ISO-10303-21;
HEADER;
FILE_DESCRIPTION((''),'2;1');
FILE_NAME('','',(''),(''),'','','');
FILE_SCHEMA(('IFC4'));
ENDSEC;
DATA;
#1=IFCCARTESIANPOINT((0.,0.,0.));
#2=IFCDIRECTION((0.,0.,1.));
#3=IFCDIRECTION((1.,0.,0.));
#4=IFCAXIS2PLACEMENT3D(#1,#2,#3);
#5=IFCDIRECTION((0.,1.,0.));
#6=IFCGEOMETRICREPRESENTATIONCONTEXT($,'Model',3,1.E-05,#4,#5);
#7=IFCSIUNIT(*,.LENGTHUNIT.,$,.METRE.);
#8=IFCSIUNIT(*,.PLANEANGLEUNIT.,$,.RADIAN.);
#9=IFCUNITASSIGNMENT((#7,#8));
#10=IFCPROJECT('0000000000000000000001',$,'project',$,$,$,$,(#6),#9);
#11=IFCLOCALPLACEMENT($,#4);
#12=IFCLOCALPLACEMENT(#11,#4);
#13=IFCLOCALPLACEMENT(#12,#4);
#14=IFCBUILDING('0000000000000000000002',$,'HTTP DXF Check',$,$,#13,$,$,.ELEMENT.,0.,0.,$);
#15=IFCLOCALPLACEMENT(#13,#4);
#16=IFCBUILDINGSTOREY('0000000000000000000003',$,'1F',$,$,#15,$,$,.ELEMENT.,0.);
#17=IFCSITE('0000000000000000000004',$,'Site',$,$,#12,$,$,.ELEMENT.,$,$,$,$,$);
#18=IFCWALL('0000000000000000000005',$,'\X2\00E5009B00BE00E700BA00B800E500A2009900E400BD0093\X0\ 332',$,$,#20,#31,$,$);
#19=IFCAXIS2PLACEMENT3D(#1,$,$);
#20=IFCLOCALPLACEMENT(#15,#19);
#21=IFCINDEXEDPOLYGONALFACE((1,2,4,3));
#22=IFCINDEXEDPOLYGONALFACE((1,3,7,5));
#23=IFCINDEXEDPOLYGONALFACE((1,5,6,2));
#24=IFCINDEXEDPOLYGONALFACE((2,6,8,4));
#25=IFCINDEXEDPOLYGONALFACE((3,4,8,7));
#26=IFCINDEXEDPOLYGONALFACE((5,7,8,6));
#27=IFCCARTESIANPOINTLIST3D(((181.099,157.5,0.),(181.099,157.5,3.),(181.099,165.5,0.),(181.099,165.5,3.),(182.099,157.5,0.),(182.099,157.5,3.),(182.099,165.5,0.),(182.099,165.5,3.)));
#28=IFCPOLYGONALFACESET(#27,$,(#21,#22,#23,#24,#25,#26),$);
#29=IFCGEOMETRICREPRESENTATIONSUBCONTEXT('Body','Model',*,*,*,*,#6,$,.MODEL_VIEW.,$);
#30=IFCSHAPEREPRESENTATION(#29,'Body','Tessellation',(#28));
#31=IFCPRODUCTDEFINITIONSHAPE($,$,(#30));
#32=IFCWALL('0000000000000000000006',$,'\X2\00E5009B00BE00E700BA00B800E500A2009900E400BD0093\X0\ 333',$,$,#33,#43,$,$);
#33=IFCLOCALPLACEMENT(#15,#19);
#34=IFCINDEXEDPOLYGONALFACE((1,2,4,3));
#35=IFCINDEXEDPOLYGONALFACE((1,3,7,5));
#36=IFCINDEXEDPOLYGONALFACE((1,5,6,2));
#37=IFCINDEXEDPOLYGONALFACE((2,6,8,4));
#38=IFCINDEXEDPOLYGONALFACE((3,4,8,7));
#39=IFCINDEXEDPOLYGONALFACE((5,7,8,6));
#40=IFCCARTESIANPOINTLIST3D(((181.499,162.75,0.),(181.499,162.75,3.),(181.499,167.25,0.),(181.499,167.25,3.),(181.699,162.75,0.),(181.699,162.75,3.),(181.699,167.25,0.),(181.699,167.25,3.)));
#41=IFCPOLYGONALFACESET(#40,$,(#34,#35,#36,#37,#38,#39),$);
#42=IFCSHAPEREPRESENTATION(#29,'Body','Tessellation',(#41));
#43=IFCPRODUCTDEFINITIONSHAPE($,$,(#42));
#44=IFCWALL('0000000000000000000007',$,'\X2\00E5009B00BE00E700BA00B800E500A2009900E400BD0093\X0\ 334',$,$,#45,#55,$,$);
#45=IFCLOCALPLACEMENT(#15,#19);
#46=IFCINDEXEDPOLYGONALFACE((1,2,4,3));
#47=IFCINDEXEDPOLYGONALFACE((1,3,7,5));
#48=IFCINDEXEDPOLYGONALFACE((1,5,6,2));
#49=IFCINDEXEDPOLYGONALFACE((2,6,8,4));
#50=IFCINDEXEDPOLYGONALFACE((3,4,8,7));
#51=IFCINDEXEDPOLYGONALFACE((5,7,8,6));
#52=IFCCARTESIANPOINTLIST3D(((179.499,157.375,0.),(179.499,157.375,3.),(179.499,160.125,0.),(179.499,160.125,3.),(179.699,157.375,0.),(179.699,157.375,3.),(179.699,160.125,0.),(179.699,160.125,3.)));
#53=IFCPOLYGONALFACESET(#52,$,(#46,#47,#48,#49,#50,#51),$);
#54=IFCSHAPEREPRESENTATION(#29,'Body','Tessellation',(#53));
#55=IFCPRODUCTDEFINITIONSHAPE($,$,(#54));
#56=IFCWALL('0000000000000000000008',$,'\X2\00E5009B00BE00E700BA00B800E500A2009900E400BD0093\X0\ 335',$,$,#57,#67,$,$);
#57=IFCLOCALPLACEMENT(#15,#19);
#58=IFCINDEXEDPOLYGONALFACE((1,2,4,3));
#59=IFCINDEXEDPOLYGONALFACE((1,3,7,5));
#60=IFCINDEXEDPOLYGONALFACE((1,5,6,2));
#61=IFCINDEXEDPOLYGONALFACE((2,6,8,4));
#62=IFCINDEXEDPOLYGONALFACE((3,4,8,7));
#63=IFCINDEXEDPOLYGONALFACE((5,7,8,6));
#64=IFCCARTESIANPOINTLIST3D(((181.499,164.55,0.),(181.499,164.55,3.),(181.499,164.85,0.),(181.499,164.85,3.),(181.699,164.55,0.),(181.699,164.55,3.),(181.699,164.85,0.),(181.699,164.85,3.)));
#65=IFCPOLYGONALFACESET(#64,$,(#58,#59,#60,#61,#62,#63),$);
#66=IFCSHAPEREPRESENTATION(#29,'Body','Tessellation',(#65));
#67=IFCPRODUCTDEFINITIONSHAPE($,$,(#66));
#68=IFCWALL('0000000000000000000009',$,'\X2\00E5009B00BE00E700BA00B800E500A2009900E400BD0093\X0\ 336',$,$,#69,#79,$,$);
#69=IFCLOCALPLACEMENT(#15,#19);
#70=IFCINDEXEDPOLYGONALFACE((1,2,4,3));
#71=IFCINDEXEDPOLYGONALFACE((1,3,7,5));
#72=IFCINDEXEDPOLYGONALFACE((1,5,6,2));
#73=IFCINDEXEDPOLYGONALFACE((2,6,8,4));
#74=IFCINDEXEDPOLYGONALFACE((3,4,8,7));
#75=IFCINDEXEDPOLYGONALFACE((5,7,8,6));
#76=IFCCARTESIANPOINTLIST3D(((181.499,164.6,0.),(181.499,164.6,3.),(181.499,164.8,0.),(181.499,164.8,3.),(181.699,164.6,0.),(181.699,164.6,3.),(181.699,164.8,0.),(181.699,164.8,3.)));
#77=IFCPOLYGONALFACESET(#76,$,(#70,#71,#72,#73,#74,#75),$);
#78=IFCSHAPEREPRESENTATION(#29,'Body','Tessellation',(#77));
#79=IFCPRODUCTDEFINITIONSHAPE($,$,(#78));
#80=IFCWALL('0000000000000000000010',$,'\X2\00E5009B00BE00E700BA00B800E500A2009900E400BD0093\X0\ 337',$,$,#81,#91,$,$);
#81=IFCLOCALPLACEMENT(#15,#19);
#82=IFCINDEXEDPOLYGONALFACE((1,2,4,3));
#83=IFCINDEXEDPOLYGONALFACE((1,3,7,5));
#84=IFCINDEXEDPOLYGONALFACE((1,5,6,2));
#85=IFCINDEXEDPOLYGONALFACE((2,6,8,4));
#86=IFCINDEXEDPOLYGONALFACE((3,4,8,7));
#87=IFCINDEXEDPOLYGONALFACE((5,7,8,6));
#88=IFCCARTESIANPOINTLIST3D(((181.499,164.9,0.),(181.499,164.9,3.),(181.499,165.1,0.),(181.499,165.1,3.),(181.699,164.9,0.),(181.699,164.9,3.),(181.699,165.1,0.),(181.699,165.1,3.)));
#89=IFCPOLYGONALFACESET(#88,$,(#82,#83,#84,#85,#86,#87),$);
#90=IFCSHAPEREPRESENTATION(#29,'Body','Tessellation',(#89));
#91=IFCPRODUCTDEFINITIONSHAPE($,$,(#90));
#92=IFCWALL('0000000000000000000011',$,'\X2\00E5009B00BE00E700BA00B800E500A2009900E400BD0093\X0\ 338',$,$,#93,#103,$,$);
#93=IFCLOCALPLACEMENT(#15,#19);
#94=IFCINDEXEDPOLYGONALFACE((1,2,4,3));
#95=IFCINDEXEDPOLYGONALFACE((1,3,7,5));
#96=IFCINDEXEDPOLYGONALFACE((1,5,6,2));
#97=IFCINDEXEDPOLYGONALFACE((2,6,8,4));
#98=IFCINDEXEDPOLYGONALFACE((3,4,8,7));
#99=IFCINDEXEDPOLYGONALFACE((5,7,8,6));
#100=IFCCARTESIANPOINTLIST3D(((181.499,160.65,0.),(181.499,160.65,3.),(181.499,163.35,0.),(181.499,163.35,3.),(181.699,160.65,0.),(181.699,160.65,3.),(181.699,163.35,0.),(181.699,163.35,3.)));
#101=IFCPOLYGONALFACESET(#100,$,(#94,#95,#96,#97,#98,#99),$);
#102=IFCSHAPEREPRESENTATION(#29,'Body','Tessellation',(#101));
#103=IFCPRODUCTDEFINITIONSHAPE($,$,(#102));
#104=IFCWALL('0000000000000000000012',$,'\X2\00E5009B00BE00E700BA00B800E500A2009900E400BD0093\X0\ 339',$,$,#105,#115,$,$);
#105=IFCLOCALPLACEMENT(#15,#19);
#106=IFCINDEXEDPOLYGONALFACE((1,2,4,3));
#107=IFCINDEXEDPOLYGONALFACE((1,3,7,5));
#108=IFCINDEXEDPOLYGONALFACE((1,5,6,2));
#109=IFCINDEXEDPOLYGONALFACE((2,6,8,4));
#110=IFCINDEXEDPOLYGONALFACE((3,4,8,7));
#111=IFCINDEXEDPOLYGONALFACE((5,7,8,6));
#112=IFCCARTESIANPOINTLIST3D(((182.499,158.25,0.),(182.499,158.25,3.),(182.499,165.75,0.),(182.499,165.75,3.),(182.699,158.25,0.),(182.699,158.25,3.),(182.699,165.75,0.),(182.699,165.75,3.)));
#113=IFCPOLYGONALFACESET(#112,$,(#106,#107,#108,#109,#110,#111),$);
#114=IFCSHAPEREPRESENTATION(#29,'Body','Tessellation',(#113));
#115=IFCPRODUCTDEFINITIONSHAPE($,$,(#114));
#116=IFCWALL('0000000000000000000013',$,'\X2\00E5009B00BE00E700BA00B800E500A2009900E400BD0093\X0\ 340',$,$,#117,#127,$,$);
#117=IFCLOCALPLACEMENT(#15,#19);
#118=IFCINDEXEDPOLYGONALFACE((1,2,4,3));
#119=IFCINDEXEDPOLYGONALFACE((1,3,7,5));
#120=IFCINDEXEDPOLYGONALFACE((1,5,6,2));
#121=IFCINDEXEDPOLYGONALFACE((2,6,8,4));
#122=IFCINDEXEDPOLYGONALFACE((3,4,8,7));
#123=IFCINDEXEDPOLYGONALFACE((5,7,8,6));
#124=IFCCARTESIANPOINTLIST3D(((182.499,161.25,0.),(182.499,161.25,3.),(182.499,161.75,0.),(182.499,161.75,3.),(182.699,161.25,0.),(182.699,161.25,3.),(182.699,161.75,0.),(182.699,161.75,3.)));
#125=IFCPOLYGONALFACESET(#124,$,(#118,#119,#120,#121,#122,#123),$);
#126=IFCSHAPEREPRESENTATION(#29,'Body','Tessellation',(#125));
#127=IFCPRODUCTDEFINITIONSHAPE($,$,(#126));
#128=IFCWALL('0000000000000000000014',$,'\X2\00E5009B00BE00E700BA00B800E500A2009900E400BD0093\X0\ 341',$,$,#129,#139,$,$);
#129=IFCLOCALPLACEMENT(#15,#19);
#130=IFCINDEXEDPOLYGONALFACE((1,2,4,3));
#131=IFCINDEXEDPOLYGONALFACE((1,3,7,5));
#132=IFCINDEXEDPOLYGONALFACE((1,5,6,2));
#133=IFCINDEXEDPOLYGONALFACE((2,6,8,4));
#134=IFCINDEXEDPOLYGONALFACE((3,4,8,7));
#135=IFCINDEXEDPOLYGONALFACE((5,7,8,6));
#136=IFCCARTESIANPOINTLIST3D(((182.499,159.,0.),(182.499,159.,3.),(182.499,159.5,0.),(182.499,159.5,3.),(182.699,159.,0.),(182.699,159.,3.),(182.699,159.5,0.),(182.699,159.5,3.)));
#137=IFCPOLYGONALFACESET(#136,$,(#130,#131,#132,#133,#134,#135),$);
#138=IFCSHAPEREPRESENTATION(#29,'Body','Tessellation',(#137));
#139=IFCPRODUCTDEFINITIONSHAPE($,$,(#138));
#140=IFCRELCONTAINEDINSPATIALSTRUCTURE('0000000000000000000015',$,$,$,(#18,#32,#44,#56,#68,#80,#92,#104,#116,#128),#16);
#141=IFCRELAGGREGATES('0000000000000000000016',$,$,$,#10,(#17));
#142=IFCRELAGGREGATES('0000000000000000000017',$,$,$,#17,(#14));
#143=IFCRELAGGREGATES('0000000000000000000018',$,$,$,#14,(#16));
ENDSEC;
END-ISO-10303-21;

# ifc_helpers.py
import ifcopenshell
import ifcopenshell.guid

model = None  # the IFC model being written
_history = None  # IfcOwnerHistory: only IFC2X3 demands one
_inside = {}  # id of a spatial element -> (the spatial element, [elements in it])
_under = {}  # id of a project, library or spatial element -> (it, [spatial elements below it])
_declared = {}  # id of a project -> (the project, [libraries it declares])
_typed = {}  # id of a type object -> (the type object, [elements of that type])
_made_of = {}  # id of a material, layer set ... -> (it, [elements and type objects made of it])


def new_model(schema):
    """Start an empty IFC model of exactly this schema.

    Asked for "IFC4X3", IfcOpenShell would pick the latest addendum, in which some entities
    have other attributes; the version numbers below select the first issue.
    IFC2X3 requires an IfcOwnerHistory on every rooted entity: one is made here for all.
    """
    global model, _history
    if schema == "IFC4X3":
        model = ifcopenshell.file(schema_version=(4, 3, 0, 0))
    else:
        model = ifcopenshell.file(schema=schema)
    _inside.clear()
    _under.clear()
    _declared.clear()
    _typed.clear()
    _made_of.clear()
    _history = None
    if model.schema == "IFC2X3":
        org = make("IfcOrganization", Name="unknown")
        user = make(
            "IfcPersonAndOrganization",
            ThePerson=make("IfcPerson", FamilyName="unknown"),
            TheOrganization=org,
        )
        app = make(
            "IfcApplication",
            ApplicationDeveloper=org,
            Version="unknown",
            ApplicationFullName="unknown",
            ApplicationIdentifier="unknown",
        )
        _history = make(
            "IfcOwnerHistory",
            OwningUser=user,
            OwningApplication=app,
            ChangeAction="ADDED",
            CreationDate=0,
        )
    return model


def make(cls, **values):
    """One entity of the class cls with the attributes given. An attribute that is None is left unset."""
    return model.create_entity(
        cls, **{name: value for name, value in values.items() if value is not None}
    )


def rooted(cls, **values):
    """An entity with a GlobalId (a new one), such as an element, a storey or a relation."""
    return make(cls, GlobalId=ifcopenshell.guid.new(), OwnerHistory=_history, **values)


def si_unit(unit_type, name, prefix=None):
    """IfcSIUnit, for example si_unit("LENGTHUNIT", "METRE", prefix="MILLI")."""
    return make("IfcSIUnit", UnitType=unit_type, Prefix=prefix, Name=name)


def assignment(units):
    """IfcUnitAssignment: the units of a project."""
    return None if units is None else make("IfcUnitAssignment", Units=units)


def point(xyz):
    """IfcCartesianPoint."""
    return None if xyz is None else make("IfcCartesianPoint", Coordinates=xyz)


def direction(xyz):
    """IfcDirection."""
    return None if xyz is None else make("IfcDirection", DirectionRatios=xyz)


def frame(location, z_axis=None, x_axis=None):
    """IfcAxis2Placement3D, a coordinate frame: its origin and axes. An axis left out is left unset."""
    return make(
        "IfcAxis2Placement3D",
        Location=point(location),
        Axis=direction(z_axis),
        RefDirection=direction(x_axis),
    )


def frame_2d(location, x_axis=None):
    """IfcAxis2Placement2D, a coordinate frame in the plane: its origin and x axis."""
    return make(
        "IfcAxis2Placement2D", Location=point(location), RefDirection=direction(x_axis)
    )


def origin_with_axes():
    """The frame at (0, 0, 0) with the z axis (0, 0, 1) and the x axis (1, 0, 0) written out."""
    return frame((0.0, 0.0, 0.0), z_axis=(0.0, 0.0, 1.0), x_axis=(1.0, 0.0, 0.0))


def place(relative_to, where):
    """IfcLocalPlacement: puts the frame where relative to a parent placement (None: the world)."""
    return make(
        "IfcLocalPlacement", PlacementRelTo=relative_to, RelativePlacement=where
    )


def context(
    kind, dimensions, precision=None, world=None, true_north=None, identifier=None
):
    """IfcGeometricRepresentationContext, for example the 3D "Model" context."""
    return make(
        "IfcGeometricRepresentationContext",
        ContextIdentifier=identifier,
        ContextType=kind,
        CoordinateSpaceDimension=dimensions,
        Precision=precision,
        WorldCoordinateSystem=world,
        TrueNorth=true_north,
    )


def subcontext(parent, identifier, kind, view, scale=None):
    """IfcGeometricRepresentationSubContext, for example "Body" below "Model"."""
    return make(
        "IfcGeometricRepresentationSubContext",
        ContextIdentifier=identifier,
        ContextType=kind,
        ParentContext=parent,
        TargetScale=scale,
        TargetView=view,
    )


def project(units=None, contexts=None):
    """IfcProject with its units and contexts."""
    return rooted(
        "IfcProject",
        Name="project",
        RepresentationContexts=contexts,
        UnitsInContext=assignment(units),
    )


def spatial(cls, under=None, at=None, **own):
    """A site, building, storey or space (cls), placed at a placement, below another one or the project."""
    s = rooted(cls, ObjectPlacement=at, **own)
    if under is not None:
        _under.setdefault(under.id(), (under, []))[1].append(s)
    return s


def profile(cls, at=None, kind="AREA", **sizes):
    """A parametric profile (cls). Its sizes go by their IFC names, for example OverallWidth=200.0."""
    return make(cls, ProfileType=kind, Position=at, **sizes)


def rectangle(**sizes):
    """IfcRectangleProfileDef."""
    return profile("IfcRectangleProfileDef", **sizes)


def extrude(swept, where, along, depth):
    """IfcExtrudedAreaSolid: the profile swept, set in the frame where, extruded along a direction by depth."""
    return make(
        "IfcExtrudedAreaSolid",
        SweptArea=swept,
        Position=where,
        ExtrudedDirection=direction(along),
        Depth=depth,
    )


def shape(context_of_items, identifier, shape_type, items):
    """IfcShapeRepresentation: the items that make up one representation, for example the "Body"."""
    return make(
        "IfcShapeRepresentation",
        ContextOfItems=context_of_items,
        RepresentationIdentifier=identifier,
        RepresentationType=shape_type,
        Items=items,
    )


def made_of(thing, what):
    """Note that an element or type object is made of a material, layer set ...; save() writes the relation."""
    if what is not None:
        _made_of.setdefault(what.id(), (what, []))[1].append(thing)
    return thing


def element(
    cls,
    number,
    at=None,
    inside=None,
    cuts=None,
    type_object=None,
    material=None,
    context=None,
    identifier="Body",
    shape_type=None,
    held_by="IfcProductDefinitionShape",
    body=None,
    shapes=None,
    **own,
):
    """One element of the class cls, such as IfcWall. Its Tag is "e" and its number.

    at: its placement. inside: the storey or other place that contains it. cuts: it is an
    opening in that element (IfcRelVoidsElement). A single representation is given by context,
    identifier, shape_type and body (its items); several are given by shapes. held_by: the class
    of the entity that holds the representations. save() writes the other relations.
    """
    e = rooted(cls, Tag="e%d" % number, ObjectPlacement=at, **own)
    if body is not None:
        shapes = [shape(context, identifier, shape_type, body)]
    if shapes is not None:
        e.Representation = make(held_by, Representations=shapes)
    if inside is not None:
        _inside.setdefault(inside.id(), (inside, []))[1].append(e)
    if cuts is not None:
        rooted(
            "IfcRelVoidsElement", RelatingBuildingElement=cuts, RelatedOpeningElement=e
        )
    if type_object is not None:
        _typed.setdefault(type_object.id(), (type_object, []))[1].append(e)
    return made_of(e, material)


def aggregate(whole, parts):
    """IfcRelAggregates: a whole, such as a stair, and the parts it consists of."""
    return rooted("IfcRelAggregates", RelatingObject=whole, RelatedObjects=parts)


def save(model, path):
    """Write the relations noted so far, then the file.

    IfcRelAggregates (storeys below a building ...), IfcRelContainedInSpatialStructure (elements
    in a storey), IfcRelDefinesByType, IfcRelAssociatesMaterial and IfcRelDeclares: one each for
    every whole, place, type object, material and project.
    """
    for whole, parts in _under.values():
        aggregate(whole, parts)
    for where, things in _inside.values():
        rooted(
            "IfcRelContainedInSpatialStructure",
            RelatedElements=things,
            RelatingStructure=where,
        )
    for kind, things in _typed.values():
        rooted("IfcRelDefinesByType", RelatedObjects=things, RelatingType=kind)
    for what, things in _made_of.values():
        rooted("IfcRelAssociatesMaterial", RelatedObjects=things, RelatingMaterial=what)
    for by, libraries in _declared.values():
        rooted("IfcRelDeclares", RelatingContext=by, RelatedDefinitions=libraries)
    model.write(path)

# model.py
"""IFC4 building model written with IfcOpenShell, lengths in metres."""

from ifc_helpers import new_model, si_unit, direction, frame, frame_2d, origin_with_axes, place, context, subcontext, project, spatial, rectangle, extrude, element, save


model = new_model("IFC4")

# Units and contexts
model_context = context("Model", 3, precision=1e-05, world=origin_with_axes(), true_north=direction((0.0, 1.0, 0.0)))
body_context = subcontext(model_context, "Body", "Model", "MODEL_VIEW")
ifc_project = project(units=[si_unit("LENGTHUNIT", "METRE"), si_unit("PLANEANGLEUNIT", "RADIAN")], contexts=[model_context])

# Site, building, storey
placement = place(None, origin_with_axes())
site_placement = place(placement, origin_with_axes())
site = spatial("IfcSite", under=ifc_project, at=site_placement, Name="Site", CompositionType="ELEMENT")
building_placement = place(site_placement, origin_with_axes())
building = spatial("IfcBuilding", under=site, at=building_placement, Name="HTTP DXF Check", CompositionType="ELEMENT", ElevationOfRefHeight=0.0, ElevationOfTerrain=0.0)
storey_placement = place(building_placement, origin_with_axes())
storey = spatial("IfcBuildingStorey", under=building, at=storey_placement, Name="1F", CompositionType="ELEMENT", Elevation=0.0)

# Walls
wall_1_placement = place(storey_placement, frame((181.599, 161.5, 0.0), z_axis=(0.0, 0.0, 1.0), x_axis=(1.0, 0.0, 0.0)))
element("IfcWall", 1, at=wall_1_placement, inside=storey, Name="å\u009b¾çº¸å¢\u0099ä½\u0093 332", context=body_context, shape_type="SweptSolid", body=[
    extrude(rectangle(XDim=1.0, YDim=8.0, at=frame_2d((0.0, 0.0), x_axis=(1.0, 0.0, 0.0))), frame((0.0, 0.0, 0.0), z_axis=(0.0, 0.0, 1.0)), (0.0, 0.0, 1.0), 3.0),
])
wall_2_placement = place(storey_placement, frame((181.599, 165.0, 0.0), z_axis=(0.0, 0.0, 1.0), x_axis=(0.0, 1.0, 0.0)))
element("IfcWall", 2, at=wall_2_placement, inside=storey, Name="å\u009b¾çº¸å¢\u0099ä½\u0093 333", context=body_context, shape_type="SweptSolid", body=[
    extrude(rectangle(XDim=4.5, YDim=0.2, at=frame_2d((0.0, 0.0), x_axis=(1.0, 0.0, 0.0))), frame((0.0, 0.0, 0.0), z_axis=(0.0, 0.0, 1.0)), (0.0, 0.0, 1.0), 3.0),
])
wall_3_placement = place(storey_placement, frame((179.599, 158.75, 0.0), z_axis=(0.0, 0.0, 1.0), x_axis=(0.0, 1.0, 0.0)))
element("IfcWall", 3, at=wall_3_placement, inside=storey, Name="å\u009b¾çº¸å¢\u0099ä½\u0093 334", context=body_context, shape_type="SweptSolid", body=[
    extrude(rectangle(XDim=2.75, YDim=0.2, at=frame_2d((0.0, 0.0), x_axis=(1.0, 0.0, 0.0))), frame((0.0, 0.0, 0.0), z_axis=(0.0, 0.0, 1.0)), (0.0, 0.0, 1.0), 3.0),
])
wall_4_placement = place(storey_placement, frame((181.599, 164.7, 0.0), z_axis=(0.0, 0.0, 1.0), x_axis=(1.0, 0.0, 0.0)))
element("IfcWall", 4, at=wall_4_placement, inside=storey, Name="å\u009b¾çº¸å¢\u0099ä½\u0093 335", context=body_context, shape_type="SweptSolid", body=[
    extrude(rectangle(XDim=0.2, YDim=0.3, at=frame_2d((0.0, 0.0), x_axis=(1.0, 0.0, 0.0))), frame((0.0, 0.0, 0.0), z_axis=(0.0, 0.0, 1.0)), (0.0, 0.0, 1.0), 3.0),
])
for number, where, z_axis, x_axis, name in (
    (5, (181.599, 164.7, 0.0), (0.0, 0.0, 1.0), (1.0, 0.0, 0.0), "å\u009b¾çº¸å¢\u0099ä½\u0093 336"),
    (6, (181.599, 165.0, 0.0), (0.0, 0.0, 1.0), (1.0, 0.0, 0.0), "å\u009b¾çº¸å¢\u0099ä½\u0093 337"),
):
    element("IfcWall", number, at=place(storey_placement, frame(where, z_axis=z_axis, x_axis=x_axis)), inside=storey, Name=name, context=body_context, shape_type="SweptSolid", body=[
        extrude(rectangle(XDim=0.2, YDim=0.2, at=frame_2d((0.0, 0.0), x_axis=(1.0, 0.0, 0.0))), frame((0.0, 0.0, 0.0), z_axis=(0.0, 0.0, 1.0)), (0.0, 0.0, 1.0), 3.0),
    ])
wall_5_placement = place(storey_placement, frame((181.599, 162.0, 0.0), z_axis=(0.0, 0.0, 1.0), x_axis=(0.0, 1.0, 0.0)))
element("IfcWall", 7, at=wall_5_placement, inside=storey, Name="å\u009b¾çº¸å¢\u0099ä½\u0093 338", context=body_context, shape_type="SweptSolid", body=[
    extrude(rectangle(XDim=2.7, YDim=0.2, at=frame_2d((0.0, 0.0), x_axis=(1.0, 0.0, 0.0))), frame((0.0, 0.0, 0.0), z_axis=(0.0, 0.0, 1.0)), (0.0, 0.0, 1.0), 3.0),
])
wall_6_placement = place(storey_placement, frame((182.599, 162.0, 0.0), z_axis=(0.0, 0.0, 1.0), x_axis=(0.0, 1.0, 0.0)))
element("IfcWall", 8, at=wall_6_placement, inside=storey, Name="å\u009b¾çº¸å¢\u0099ä½\u0093 339", context=body_context, shape_type="SweptSolid", body=[
    extrude(rectangle(XDim=7.5, YDim=0.2, at=frame_2d((0.0, 0.0), x_axis=(1.0, 0.0, 0.0))), frame((0.0, 0.0, 0.0), z_axis=(0.0, 0.0, 1.0)), (0.0, 0.0, 1.0), 3.0),
])
for number, where, z_axis, x_axis, name in (
    (9, (182.599, 161.5, 0.0), (0.0, 0.0, 1.0), (0.0, 1.0, 0.0), "å\u009b¾çº¸å¢\u0099ä½\u0093 340"),
    (10, (182.599, 159.25, 0.0), (0.0, 0.0, 1.0), (0.0, -1.0, 0.0), "å\u009b¾çº¸å¢\u0099ä½\u0093 341"),
):
    element("IfcWall", number, at=place(storey_placement, frame(where, z_axis=z_axis, x_axis=x_axis)), inside=storey, Name=name, context=body_context, shape_type="SweptSolid", body=[
        extrude(rectangle(XDim=0.5, YDim=0.2, at=frame_2d((0.0, 0.0), x_axis=(1.0, 0.0, 0.0))), frame((0.0, 0.0, 0.0), z_axis=(0.0, 0.0, 1.0)), (0.0, 0.0, 1.0), 3.0),
    ])

save(model, "model.ifc")
